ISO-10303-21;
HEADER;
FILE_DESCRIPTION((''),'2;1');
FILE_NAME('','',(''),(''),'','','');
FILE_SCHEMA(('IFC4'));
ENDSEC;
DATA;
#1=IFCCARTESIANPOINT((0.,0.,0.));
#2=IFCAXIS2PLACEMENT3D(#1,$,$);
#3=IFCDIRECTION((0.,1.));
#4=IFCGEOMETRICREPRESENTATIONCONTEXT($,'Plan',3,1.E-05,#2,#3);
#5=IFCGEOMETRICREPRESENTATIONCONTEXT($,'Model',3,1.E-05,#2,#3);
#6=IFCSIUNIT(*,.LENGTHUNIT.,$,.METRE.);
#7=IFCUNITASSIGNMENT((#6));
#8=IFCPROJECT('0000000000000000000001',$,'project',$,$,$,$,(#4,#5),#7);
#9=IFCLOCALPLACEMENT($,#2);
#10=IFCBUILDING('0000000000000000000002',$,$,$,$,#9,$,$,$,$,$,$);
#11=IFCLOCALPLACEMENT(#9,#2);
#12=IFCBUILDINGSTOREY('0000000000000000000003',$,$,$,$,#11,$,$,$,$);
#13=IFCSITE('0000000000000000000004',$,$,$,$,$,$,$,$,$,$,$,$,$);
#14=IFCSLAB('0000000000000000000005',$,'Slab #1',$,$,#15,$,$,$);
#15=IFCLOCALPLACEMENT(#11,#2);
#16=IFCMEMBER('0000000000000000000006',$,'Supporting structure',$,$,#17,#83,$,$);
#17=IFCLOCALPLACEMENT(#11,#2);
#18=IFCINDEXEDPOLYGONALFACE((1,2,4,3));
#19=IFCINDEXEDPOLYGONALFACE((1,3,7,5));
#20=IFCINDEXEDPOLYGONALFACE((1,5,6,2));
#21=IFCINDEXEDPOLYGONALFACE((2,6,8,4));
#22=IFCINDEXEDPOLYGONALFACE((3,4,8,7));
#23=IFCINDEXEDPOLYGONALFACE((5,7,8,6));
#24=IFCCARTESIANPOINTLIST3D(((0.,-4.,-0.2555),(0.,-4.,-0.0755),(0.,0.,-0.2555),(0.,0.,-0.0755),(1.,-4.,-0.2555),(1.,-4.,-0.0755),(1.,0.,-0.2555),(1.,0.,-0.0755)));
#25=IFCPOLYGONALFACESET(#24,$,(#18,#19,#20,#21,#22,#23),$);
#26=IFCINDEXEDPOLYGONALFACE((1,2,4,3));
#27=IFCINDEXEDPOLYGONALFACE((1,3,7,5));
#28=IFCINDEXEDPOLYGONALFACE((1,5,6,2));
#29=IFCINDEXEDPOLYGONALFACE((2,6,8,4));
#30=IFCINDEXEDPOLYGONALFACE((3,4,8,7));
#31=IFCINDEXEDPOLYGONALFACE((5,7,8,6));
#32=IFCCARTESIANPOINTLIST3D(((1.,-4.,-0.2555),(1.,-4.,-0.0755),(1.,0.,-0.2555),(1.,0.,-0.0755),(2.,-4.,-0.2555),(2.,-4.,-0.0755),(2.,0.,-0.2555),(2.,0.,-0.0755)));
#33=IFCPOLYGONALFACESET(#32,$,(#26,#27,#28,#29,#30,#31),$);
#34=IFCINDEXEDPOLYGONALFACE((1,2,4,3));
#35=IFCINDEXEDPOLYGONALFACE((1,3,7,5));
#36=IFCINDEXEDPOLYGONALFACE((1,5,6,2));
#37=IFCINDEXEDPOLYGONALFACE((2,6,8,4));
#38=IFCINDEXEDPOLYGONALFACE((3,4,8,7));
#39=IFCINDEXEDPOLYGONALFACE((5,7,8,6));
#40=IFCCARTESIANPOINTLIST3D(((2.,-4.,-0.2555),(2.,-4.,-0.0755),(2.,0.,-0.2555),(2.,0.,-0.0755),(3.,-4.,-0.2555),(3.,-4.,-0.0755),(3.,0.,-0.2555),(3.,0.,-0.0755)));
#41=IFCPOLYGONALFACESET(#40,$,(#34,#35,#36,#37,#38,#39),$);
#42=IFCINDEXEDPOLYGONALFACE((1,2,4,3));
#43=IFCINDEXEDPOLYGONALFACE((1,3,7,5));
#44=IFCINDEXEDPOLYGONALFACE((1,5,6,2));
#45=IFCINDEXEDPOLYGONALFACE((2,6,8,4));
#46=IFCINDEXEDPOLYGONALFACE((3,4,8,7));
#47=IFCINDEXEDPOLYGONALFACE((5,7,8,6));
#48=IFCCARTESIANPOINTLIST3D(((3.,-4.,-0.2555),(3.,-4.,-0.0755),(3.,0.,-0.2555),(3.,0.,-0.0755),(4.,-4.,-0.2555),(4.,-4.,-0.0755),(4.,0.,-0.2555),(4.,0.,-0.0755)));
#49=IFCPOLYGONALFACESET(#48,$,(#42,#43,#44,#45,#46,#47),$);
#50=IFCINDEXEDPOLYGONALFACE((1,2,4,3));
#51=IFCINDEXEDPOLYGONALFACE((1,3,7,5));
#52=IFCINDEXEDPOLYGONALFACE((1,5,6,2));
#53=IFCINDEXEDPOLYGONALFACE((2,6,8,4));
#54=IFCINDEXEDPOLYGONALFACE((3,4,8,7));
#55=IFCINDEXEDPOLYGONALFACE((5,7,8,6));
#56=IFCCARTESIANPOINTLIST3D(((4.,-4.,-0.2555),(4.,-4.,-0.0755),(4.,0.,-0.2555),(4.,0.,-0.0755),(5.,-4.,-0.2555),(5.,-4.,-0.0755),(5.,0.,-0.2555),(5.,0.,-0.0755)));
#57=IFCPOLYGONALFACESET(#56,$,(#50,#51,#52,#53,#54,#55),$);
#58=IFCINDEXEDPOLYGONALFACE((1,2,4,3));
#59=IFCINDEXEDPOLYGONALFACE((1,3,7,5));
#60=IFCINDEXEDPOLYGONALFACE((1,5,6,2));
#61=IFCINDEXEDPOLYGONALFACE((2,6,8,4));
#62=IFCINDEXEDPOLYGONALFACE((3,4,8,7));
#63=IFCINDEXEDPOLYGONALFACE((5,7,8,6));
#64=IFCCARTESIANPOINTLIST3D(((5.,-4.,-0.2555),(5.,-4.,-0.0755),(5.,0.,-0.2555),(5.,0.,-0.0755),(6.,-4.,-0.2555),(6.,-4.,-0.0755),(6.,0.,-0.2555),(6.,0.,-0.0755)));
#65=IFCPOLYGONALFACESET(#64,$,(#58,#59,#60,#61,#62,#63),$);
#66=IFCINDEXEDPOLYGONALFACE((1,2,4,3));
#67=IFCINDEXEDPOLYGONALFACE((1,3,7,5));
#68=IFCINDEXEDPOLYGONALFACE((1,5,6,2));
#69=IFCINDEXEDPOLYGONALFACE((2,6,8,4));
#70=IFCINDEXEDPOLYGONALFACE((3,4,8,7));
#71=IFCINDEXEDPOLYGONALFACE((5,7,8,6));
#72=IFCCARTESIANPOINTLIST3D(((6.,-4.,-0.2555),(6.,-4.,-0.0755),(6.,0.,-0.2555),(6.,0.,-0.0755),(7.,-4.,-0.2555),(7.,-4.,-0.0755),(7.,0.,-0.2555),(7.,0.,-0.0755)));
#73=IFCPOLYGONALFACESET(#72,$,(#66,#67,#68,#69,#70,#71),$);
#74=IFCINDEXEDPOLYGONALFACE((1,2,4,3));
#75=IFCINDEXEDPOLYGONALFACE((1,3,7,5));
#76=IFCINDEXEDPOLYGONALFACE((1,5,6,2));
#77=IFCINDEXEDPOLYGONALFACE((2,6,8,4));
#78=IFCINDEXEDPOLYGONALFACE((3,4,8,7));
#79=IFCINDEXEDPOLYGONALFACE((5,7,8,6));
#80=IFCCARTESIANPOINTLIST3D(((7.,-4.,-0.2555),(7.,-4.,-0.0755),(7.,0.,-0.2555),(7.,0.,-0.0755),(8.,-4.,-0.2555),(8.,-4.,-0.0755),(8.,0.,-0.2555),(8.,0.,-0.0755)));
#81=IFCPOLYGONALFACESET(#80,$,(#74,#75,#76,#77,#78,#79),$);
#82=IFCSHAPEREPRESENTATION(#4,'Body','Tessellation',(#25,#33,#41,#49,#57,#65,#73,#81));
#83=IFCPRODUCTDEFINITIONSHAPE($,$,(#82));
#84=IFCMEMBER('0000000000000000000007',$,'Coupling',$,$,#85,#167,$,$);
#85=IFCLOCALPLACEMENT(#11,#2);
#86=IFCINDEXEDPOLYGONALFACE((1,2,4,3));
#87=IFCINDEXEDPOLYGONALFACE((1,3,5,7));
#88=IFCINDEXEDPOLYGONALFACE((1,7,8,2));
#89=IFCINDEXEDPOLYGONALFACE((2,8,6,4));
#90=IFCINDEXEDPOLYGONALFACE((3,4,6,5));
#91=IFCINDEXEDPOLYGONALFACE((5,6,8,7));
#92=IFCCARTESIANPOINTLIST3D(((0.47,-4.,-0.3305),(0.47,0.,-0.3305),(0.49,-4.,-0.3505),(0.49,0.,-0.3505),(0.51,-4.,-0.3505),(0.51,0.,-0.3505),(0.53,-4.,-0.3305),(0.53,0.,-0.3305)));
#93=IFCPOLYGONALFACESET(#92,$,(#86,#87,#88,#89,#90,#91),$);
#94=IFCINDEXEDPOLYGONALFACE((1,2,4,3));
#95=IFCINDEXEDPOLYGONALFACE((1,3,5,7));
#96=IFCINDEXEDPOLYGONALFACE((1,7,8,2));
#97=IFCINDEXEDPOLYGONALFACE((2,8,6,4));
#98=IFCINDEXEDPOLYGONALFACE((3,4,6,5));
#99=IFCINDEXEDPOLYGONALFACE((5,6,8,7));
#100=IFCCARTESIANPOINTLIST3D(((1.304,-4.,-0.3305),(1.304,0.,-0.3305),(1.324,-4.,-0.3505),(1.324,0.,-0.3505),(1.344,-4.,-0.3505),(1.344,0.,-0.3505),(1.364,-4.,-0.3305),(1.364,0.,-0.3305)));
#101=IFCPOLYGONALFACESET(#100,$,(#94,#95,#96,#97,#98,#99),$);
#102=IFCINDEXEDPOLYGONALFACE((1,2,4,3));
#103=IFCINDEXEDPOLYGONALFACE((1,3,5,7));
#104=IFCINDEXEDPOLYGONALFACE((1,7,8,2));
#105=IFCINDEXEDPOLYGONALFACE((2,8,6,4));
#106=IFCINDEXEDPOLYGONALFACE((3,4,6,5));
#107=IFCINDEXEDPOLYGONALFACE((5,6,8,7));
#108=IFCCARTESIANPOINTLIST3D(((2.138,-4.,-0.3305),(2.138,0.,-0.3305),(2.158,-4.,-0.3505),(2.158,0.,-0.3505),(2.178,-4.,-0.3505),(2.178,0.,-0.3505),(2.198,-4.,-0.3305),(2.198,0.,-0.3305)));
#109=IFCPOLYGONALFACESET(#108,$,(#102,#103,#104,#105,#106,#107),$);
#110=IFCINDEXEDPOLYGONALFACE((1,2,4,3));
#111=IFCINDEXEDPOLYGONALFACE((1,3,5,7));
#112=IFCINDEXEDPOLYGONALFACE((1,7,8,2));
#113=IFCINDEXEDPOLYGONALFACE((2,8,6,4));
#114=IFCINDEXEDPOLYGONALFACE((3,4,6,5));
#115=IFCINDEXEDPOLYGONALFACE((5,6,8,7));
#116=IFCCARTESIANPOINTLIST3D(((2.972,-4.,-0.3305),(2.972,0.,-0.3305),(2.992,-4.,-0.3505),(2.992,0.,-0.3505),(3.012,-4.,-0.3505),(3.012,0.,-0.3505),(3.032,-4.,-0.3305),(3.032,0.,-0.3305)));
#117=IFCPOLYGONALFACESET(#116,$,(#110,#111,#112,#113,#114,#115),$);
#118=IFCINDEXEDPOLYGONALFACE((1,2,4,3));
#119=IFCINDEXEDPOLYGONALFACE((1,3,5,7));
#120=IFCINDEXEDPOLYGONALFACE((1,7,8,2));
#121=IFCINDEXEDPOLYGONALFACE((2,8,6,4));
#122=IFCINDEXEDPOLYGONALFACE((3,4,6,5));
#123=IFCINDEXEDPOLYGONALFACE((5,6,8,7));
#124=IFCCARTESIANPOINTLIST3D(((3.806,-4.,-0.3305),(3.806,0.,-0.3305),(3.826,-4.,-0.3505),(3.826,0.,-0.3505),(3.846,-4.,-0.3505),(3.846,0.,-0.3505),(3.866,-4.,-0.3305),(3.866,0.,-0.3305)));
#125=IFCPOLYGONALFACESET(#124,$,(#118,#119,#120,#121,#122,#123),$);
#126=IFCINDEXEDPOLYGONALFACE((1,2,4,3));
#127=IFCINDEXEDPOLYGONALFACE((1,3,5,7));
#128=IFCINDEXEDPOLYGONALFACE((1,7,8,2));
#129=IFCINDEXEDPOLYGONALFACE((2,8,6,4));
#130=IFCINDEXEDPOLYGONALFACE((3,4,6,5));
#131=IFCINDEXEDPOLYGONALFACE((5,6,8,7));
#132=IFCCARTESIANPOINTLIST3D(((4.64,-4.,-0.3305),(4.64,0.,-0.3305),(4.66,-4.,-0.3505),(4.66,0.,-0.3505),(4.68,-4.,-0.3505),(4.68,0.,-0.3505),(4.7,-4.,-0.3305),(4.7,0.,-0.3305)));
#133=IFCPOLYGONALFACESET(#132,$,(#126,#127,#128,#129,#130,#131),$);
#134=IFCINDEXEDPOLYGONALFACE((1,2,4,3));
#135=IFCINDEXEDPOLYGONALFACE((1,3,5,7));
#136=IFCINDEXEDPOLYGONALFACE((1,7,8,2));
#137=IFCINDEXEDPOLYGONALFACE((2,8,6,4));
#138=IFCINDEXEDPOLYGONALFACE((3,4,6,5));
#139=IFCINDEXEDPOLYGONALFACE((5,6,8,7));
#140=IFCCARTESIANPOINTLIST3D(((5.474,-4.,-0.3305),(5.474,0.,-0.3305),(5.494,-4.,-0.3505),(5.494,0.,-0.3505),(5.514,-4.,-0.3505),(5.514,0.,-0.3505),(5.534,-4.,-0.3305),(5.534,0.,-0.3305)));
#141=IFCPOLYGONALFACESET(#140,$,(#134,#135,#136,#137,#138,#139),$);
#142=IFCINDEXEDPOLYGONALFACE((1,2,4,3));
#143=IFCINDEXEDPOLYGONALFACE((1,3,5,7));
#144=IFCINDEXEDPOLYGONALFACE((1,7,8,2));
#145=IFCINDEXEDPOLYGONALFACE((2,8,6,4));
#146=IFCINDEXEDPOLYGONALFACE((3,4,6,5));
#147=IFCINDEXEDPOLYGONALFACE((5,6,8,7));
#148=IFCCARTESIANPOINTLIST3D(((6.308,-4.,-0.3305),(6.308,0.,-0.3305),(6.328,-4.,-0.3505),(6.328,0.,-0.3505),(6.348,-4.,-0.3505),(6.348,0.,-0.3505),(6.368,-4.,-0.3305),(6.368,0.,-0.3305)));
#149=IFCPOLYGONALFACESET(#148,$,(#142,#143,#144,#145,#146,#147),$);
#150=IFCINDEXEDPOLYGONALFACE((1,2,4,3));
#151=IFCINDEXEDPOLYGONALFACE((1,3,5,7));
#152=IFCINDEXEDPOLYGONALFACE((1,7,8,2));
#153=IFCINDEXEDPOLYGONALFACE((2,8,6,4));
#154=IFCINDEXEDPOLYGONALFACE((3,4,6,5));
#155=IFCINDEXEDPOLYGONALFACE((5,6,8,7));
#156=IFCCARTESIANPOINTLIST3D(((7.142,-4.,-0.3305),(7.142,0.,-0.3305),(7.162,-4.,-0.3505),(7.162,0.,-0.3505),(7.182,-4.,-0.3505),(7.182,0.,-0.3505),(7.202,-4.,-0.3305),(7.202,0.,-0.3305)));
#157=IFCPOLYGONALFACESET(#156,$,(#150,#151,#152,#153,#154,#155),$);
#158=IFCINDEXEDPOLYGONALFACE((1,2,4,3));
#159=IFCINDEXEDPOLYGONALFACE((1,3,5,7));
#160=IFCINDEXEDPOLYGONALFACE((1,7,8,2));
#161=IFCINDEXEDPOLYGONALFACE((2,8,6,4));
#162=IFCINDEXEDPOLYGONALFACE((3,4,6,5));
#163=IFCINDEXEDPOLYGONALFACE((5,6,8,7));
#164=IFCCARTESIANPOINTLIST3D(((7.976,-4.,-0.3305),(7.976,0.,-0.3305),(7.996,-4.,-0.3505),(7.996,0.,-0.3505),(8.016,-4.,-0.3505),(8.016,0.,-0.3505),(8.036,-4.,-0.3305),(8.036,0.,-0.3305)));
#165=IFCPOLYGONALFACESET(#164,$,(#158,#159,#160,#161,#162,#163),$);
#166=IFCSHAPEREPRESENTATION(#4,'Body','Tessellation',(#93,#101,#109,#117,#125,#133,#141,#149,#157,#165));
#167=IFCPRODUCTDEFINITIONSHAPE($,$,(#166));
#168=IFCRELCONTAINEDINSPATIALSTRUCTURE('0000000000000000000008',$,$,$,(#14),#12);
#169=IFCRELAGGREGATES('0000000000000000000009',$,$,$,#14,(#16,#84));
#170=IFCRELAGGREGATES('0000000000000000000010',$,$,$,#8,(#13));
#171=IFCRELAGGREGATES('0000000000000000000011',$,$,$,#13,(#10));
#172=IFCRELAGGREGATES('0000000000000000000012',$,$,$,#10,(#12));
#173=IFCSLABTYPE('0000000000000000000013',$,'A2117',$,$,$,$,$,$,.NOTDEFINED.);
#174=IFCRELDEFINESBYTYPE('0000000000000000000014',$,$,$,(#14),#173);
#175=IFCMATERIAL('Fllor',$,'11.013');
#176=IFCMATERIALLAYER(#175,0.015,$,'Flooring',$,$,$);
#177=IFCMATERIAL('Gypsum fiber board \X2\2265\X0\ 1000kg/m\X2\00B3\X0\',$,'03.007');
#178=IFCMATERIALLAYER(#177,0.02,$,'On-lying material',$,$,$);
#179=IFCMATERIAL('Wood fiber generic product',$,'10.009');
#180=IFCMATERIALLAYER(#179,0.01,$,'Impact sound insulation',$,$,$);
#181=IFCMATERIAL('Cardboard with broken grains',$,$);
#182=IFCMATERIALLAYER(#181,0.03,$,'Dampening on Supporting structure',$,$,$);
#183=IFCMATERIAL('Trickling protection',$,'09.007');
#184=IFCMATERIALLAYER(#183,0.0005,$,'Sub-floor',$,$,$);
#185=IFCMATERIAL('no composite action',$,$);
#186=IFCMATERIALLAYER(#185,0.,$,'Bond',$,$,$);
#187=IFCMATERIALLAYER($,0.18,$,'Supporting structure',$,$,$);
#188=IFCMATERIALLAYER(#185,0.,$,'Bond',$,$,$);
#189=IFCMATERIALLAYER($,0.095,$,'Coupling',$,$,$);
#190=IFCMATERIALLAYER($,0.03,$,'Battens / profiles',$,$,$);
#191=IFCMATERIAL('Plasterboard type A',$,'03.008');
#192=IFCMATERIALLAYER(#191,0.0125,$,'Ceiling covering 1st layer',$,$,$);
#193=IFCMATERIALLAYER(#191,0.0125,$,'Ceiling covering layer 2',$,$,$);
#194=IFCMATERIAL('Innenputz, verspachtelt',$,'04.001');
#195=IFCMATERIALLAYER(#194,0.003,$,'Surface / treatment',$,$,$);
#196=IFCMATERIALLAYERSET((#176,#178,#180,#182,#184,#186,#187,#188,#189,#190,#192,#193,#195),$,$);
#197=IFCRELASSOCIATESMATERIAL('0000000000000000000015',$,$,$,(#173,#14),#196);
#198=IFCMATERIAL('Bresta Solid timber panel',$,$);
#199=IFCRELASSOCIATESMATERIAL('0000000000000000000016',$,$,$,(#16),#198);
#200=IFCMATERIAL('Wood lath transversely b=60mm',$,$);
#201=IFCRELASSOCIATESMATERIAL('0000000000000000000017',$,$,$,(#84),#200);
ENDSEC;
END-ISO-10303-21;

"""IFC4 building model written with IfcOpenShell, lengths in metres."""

from ifc_helpers import new_model, si_unit, direction, frame, frame_2d, origin, place, context, project, spatial, polyline, rectangle, outline, extrude, material, layer, layer_set, type_object, element, aggregate, save


model = new_model("IFC4")

# Units and contexts
plan_context = context("Plan", 3, precision=1e-05, world=origin(), true_north=direction((0.0, 1.0)))
model_context = context("Model", 3, precision=1e-05, world=origin(), true_north=direction((0.0, 1.0)))
ifc_project = project(units=[si_unit("LENGTHUNIT", "METRE")], contexts=[plan_context, model_context])

# Site, building, storey
site = spatial("IfcSite", under=ifc_project)
building_placement = place(None, origin())
building = spatial("IfcBuilding", under=site, at=building_placement)
storey_placement = place(building_placement, origin())
storey = spatial("IfcBuildingStorey", under=building, at=storey_placement)

# Slab, members
ifc_material_1 = material(Name="Fllor", Category="11.013")
ifc_layer_1 = layer(ifc_material_1, 0.015, Name="Flooring")
ifc_material_2 = material(Name="Gypsum fiber board ≥ 1000kg/m³", Category="03.007")
ifc_layer_2 = layer(ifc_material_2, 0.02, Name="On-lying material")
ifc_material_3 = material(Name="Wood fiber generic product", Category="10.009")
ifc_layer_3 = layer(ifc_material_3, 0.01, Name="Impact sound insulation")
ifc_material_4 = material(Name="Cardboard with broken grains")
ifc_layer_4 = layer(ifc_material_4, 0.03, Name="Dampening on Supporting structure")
ifc_material_5 = material(Name="Trickling protection", Category="09.007")
ifc_layer_5 = layer(ifc_material_5, 0.0005, Name="Sub-floor")
ifc_material_6 = material(Name="no composite action")
ifc_layer_6 = layer(ifc_material_6, 0.0, Name="Bond")
ifc_layer_7 = layer(None, 0.18, Name="Supporting structure")
ifc_layer_8 = layer(ifc_material_6, 0.0, Name="Bond")
ifc_layer_9 = layer(None, 0.095, Name="Coupling")
ifc_layer_10 = layer(None, 0.03, Name="Battens / profiles")
ifc_material_7 = material(Name="Plasterboard type A", Category="03.008")
ifc_layer_11 = layer(ifc_material_7, 0.0125, Name="Ceiling covering 1st layer")
ifc_layer_12 = layer(ifc_material_7, 0.0125, Name="Ceiling covering layer 2")
ifc_material_8 = material(Name="Innenputz, verspachtelt", Category="04.001")
ifc_layer_13 = layer(ifc_material_8, 0.003, Name="Surface / treatment")
ifc_layer_set = layer_set([ifc_layer_1, ifc_layer_2, ifc_layer_3, ifc_layer_4, ifc_layer_5, ifc_layer_6, ifc_layer_7, ifc_layer_8, ifc_layer_9, ifc_layer_10, ifc_layer_11, ifc_layer_12, ifc_layer_13])
slab_type = type_object("IfcSlabType", Name="A2117", PredefinedType="NOTDEFINED", material=ifc_layer_set)
slab_placement = place(None, frame((0.0, 0.0, 0.0), z_axis=(0.0, 0.0, -1.0), x_axis=(1.0, 0.0, 0.0)))
slab = element("IfcSlab", 1, at=slab_placement, inside=storey, type_object=slab_type, material=ifc_layer_set, Name="Slab #1")
ifc_material_9 = material(Name="Bresta Solid timber panel")
member_1_placement = place(slab_placement, origin())
member_1 = element("IfcMember", 2, at=member_1_placement, material=ifc_material_9, Name="Supporting structure", context=plan_context, shape_type="SweptSolid", body=[
    extrude(rectangle(XDim=1.0, YDim=0.18, at=frame_2d((0.5, 0.09), x_axis=(1.0, 0.0))), frame((0.0, 4.0, 0.0755), z_axis=(0.0, -1.0, 0.0), x_axis=(1.0, 0.0, 0.0)), (0.0, 0.0, 1.0), 4.0),
    extrude(rectangle(XDim=1.0, YDim=0.18, at=frame_2d((0.5, 0.09), x_axis=(1.0, 0.0))), frame((1.0, 4.0, 0.0755), z_axis=(0.0, -1.0, 0.0), x_axis=(1.0, 0.0, 0.0)), (0.0, 0.0, 1.0), 4.0),
    extrude(rectangle(XDim=1.0, YDim=0.18, at=frame_2d((0.5, 0.09), x_axis=(1.0, 0.0))), frame((2.0, 4.0, 0.0755), z_axis=(0.0, -1.0, 0.0), x_axis=(1.0, 0.0, 0.0)), (0.0, 0.0, 1.0), 4.0),
    extrude(rectangle(XDim=1.0, YDim=0.18, at=frame_2d((0.5, 0.09), x_axis=(1.0, 0.0))), frame((3.0, 4.0, 0.0755), z_axis=(0.0, -1.0, 0.0), x_axis=(1.0, 0.0, 0.0)), (0.0, 0.0, 1.0), 4.0),
    extrude(rectangle(XDim=1.0, YDim=0.18, at=frame_2d((0.5, 0.09), x_axis=(1.0, 0.0))), frame((4.0, 4.0, 0.0755), z_axis=(0.0, -1.0, 0.0), x_axis=(1.0, 0.0, 0.0)), (0.0, 0.0, 1.0), 4.0),
    extrude(rectangle(XDim=1.0, YDim=0.18, at=frame_2d((0.5, 0.09), x_axis=(1.0, 0.0))), frame((5.0, 4.0, 0.0755), z_axis=(0.0, -1.0, 0.0), x_axis=(1.0, 0.0, 0.0)), (0.0, 0.0, 1.0), 4.0),
    extrude(rectangle(XDim=1.0, YDim=0.18, at=frame_2d((0.5, 0.09), x_axis=(1.0, 0.0))), frame((6.0, 4.0, 0.0755), z_axis=(0.0, -1.0, 0.0), x_axis=(1.0, 0.0, 0.0)), (0.0, 0.0, 1.0), 4.0),
    extrude(rectangle(XDim=1.0, YDim=0.18, at=frame_2d((0.5, 0.09), x_axis=(1.0, 0.0))), frame((7.0, 4.0, 0.0755), z_axis=(0.0, -1.0, 0.0), x_axis=(1.0, 0.0, 0.0)), (0.0, 0.0, 1.0), 4.0),
])
ifc_material_10 = material(Name="Wood lath transversely b=60mm")
member_2_placement = place(slab_placement, origin())
member_2 = element("IfcMember", 3, at=member_2_placement, material=ifc_material_10, Name="Coupling", context=plan_context, shape_type="SweptSolid", body=[
    extrude(outline(polyline([(0.0, 0.0), (0.06, 0.0), (0.04, 0.02), (0.02, 0.02), (0.0, 0.0)])), frame((0.47, 4.0, 0.3305), z_axis=(0.0, -1.0, 0.0), x_axis=(1.0, 0.0, 0.0)), (0.0, 0.0, 1.0), 4.0),
    extrude(outline(polyline([(0.0, 0.0), (0.06, 0.0), (0.04, 0.02), (0.02, 0.02), (0.0, 0.0)])), frame((1.304, 4.0, 0.3305), z_axis=(0.0, -1.0, 0.0), x_axis=(1.0, 0.0, 0.0)), (0.0, 0.0, 1.0), 4.0),
    extrude(outline(polyline([(0.0, 0.0), (0.06, 0.0), (0.04, 0.02), (0.02, 0.02), (0.0, 0.0)])), frame((2.138, 4.0, 0.3305), z_axis=(0.0, -1.0, 0.0), x_axis=(1.0, 0.0, 0.0)), (0.0, 0.0, 1.0), 4.0),
    extrude(outline(polyline([(0.0, 0.0), (0.06, 0.0), (0.04, 0.02), (0.02, 0.02), (0.0, 0.0)])), frame((2.972, 4.0, 0.3305), z_axis=(0.0, -1.0, 0.0), x_axis=(1.0, 0.0, 0.0)), (0.0, 0.0, 1.0), 4.0),
    extrude(outline(polyline([(0.0, 0.0), (0.06, 0.0), (0.04, 0.02), (0.02, 0.02), (0.0, 0.0)])), frame((3.806, 4.0, 0.3305), z_axis=(0.0, -1.0, 0.0), x_axis=(1.0, 0.0, 0.0)), (0.0, 0.0, 1.0), 4.0),
    extrude(outline(polyline([(0.0, 0.0), (0.06, 0.0), (0.04, 0.02), (0.02, 0.02), (0.0, 0.0)])), frame((4.64, 4.0, 0.3305), z_axis=(0.0, -1.0, 0.0), x_axis=(1.0, 0.0, 0.0)), (0.0, 0.0, 1.0), 4.0),
    extrude(outline(polyline([(0.0, 0.0), (0.06, 0.0), (0.04, 0.02), (0.02, 0.02), (0.0, 0.0)])), frame((5.474, 4.0, 0.3305), z_axis=(0.0, -1.0, 0.0), x_axis=(1.0, 0.0, 0.0)), (0.0, 0.0, 1.0), 4.0),
    extrude(outline(polyline([(0.0, 0.0), (0.06, 0.0), (0.04, 0.02), (0.02, 0.02), (0.0, 0.0)])), frame((6.308, 4.0, 0.3305), z_axis=(0.0, -1.0, 0.0), x_axis=(1.0, 0.0, 0.0)), (0.0, 0.0, 1.0), 4.0),
    extrude(outline(polyline([(0.0, 0.0), (0.06, 0.0), (0.04, 0.02), (0.02, 0.02), (0.0, 0.0)])), frame((7.142, 4.0, 0.3305), z_axis=(0.0, -1.0, 0.0), x_axis=(1.0, 0.0, 0.0)), (0.0, 0.0, 1.0), 4.0),
    extrude(outline(polyline([(0.0, 0.0), (0.06, 0.0), (0.04, 0.02), (0.02, 0.02), (0.0, 0.0)])), frame((7.976, 4.0, 0.3305), z_axis=(0.0, -1.0, 0.0), x_axis=(1.0, 0.0, 0.0)), (0.0, 0.0, 1.0), 4.0),
])
aggregate(slab, [member_1, member_2])

save(model, "model.ifc")
